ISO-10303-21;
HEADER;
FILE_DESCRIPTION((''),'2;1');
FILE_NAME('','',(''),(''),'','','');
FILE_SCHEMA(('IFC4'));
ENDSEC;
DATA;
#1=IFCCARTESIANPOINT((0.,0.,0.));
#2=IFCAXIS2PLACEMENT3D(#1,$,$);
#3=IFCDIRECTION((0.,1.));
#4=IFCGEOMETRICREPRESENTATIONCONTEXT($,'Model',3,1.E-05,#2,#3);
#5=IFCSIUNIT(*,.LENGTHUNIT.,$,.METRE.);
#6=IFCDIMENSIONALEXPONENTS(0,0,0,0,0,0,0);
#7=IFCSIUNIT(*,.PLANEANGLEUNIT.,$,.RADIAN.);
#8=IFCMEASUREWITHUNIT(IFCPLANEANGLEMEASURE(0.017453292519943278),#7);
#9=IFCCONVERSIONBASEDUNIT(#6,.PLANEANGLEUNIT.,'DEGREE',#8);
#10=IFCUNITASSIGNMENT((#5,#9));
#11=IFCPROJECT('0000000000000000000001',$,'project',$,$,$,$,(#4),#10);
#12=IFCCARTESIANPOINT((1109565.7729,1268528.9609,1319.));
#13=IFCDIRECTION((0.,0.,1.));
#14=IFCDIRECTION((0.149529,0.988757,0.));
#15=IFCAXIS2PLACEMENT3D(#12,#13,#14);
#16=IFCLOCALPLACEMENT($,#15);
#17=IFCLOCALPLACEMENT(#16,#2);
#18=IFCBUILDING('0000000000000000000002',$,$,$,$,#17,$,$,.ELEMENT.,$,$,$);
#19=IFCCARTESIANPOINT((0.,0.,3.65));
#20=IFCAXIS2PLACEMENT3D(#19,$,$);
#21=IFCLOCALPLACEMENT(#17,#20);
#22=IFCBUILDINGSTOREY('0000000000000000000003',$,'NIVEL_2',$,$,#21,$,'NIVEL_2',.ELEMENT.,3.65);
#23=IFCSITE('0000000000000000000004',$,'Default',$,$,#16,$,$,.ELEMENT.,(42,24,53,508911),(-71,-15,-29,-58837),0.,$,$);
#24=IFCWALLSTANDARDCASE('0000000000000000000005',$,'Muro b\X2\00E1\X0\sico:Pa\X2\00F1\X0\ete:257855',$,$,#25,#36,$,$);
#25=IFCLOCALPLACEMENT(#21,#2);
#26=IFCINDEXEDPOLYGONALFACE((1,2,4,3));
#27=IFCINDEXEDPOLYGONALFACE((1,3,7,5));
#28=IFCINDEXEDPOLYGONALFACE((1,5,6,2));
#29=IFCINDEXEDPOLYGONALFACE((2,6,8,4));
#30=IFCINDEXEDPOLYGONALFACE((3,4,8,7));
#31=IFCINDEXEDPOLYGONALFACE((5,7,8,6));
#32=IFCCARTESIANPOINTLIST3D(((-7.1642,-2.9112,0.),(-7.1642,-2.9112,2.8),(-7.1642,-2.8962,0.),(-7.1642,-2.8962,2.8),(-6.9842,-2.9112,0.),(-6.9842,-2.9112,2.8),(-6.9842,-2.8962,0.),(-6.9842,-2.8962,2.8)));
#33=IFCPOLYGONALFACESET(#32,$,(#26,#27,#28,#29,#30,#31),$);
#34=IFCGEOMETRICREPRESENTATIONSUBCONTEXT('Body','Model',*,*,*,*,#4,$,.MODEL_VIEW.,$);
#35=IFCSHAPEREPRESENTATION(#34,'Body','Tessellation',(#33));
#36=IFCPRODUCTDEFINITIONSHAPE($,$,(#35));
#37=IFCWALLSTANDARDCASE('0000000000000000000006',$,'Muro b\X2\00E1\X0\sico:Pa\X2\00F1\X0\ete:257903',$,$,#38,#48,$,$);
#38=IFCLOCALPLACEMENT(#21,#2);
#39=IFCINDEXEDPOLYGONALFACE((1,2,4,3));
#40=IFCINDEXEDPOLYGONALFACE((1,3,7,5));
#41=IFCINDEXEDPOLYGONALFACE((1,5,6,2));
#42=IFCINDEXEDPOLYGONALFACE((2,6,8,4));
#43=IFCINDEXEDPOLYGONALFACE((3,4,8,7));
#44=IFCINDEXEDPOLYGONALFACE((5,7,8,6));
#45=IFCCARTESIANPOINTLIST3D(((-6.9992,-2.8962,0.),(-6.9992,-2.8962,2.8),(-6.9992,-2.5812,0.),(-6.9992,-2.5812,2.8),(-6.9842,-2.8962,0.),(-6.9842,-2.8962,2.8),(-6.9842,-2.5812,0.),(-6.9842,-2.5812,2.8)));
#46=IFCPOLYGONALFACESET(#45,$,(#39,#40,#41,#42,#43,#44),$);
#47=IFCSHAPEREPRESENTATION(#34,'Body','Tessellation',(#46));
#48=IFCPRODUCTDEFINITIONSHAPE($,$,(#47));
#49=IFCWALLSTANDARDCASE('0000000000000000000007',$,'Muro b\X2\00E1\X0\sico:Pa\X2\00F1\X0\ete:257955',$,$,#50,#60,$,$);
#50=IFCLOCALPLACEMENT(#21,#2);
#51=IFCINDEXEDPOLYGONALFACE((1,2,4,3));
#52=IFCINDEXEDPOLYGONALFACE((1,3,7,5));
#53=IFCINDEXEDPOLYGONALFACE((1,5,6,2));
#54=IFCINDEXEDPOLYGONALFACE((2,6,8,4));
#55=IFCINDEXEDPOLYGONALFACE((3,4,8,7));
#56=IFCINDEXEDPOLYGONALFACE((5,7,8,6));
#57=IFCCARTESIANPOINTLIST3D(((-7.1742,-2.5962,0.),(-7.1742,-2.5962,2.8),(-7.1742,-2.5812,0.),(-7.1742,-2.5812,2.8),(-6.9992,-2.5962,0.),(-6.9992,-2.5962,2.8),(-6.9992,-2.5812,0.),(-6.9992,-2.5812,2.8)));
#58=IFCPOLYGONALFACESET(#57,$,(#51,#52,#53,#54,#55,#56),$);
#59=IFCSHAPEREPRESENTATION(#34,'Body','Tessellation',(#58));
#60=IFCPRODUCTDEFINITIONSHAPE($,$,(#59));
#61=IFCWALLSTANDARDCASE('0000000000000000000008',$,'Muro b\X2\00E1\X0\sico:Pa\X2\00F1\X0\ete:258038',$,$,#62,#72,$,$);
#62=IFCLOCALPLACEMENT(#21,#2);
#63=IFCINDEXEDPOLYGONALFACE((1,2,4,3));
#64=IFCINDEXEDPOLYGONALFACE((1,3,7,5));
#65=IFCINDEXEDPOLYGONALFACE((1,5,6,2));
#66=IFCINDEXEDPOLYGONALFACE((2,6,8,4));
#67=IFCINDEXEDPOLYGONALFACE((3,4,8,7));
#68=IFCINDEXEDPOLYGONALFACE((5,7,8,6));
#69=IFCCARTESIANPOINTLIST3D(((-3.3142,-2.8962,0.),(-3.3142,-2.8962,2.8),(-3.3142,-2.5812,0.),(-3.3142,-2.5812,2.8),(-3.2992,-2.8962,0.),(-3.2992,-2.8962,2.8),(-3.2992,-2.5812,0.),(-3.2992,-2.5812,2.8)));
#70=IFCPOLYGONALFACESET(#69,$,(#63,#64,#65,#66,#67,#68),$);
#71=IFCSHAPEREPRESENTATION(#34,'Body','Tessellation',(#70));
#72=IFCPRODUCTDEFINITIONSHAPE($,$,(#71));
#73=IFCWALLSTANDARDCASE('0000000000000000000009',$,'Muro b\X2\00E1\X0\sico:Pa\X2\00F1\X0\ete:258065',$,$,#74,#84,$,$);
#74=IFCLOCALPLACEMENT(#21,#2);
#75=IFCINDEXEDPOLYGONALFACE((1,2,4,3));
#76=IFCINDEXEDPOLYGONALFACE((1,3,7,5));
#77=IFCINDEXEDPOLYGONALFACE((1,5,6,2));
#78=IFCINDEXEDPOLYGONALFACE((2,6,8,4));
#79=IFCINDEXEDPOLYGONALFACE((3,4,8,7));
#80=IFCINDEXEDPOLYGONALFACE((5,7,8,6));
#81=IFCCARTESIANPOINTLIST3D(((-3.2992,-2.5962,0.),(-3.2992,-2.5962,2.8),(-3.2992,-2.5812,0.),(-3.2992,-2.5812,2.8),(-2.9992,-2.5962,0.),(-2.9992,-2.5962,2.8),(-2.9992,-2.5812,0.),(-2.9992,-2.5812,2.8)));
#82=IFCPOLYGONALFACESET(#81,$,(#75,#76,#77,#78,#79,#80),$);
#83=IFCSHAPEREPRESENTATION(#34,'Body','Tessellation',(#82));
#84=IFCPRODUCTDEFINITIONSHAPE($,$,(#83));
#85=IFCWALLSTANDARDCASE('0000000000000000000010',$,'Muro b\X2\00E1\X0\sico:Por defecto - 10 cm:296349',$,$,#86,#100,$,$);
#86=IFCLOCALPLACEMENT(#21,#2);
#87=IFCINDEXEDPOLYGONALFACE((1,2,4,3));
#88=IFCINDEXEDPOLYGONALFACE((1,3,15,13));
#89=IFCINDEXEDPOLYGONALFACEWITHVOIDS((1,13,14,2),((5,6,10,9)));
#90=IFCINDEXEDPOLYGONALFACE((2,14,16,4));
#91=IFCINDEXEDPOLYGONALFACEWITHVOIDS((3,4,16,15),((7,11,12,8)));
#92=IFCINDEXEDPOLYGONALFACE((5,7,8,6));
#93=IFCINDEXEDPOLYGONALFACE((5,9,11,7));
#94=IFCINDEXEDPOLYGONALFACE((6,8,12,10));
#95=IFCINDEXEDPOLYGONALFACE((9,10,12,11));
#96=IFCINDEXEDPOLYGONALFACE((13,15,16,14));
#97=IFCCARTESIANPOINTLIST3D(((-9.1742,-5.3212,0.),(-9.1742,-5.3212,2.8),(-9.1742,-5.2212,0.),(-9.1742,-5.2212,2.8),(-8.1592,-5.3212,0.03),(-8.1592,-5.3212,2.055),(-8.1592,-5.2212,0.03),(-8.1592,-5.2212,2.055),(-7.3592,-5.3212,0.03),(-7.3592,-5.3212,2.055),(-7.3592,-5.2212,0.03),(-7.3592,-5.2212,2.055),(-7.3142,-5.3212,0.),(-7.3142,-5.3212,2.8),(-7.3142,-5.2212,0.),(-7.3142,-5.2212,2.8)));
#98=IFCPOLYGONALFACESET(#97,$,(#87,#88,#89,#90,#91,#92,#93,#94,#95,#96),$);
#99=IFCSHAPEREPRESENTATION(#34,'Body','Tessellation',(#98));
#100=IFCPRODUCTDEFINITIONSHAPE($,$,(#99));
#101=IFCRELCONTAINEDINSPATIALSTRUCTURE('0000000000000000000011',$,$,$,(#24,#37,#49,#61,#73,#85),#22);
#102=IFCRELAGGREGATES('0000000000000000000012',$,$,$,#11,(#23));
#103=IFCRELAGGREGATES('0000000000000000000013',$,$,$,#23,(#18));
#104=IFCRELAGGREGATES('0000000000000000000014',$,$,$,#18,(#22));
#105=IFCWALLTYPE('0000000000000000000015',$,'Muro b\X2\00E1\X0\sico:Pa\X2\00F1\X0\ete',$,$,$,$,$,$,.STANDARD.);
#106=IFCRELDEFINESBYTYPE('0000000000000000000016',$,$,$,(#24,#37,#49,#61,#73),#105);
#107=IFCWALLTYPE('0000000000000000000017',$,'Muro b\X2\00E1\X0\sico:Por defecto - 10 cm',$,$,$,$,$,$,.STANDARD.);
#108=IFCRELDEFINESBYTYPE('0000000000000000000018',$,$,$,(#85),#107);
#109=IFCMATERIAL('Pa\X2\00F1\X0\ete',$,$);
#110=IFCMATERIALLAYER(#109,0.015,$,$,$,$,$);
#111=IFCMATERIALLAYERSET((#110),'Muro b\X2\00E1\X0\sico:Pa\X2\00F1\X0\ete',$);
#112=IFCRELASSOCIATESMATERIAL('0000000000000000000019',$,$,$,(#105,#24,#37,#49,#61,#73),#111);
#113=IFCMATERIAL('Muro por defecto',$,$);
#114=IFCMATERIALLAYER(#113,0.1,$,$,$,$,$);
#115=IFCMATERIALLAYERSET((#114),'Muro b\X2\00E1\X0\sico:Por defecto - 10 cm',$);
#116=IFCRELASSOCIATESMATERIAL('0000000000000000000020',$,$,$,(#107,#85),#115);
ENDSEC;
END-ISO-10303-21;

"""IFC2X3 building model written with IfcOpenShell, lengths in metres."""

from ifc_helpers import new_model, entity, si_unit, converted_unit, direction, frame, frame_2d, origin, place, context, subcontext, project, spatial, rectangle, extrude, material, layer, layer_set, layer_usage, type_object, element, save


model = new_model("IFC2X3")

# Units and contexts
model_context = context("Model", 3, precision=1e-05, world=origin(), true_north=direction((0.0, 1.0)))
body_context = subcontext(model_context, "Body", "Model", "MODEL_VIEW")
ifc_project = project(units=[si_unit("LENGTHUNIT", "METRE"), converted_unit("PLANEANGLEUNIT", "DEGREE", entity("IfcPlaneAngleMeasure", 0.017453292519943278), si_unit("PLANEANGLEUNIT", "RADIAN"), dimensions=[0, 0, 0, 0, 0, 0, 0])], contexts=[model_context])

# Site, building, storey
site_placement = place(None, frame((1109565.7729, 1268528.9609, 1319.0), z_axis=(0.0, 0.0, 1.0), x_axis=(0.149529, 0.988757, 0.0)))
site = spatial("IfcSite", under=ifc_project, at=site_placement, Name="Default", CompositionType="ELEMENT", RefLatitude=(42, 24, 53, 508911), RefLongitude=(-71, -15, -29, -58837), RefElevation=0.0)
building_placement = place(site_placement, origin())
building = spatial("IfcBuilding", under=site, at=building_placement, CompositionType="ELEMENT")
storey_placement = place(building_placement, frame((0.0, 0.0, 3.65)))
storey = spatial("IfcBuildingStorey", under=building, at=storey_placement, Name="NIVEL_2", LongName="NIVEL_2", CompositionType="ELEMENT", Elevation=3.65)

# Shared definitions
ifc_material_1 = material(Name="Pañete")

# Walls
ifc_layer_1 = layer(ifc_material_1, 0.015)
ifc_layer_set_1 = layer_set([ifc_layer_1], Name="Muro básico:Pañete")
wall_type_1 = type_object("IfcWallType", Name="Muro básico:Pañete", PredefinedType="STANDARD", material=ifc_layer_set_1)
ifc_layer_usage_1 = layer_usage(ifc_layer_set_1, "AXIS2", "POSITIVE", -0.0075)
wall_1_placement = place(storey_placement, frame((-7.1642, -2.9037, 0.0)))
element("IfcWallStandardCase", 1, at=wall_1_placement, inside=storey, type_object=wall_type_1, material=ifc_layer_usage_1, Name="Muro básico:Pañete:257855", context=body_context, shape_type="SweptSolid", body=[
    extrude(rectangle(XDim=0.18, YDim=0.015, at=frame_2d((0.09, 0.0), x_axis=(-1.0, 0.0))), origin(), (0.0, 0.0, 1.0), 2.8),
])
ifc_layer_usage_2 = layer_usage(ifc_layer_set_1, "AXIS2", "POSITIVE", -0.0075)
wall_2_placement = place(storey_placement, frame((-6.9917, -2.8962, 0.0), z_axis=(0.0, 0.0, 1.0), x_axis=(0.0, 1.0, 0.0)))
element("IfcWallStandardCase", 2, at=wall_2_placement, inside=storey, type_object=wall_type_1, material=ifc_layer_usage_2, Name="Muro básico:Pañete:257903", context=body_context, shape_type="SweptSolid", body=[
    extrude(rectangle(XDim=0.315, YDim=0.015, at=frame_2d((0.1575, 0.0), x_axis=(-1.0, 0.0))), origin(), (0.0, 0.0, 1.0), 2.8),
])
ifc_layer_usage_3 = layer_usage(ifc_layer_set_1, "AXIS2", "POSITIVE", -0.0075)
wall_3_placement = place(storey_placement, frame((-6.9992, -2.5887, 0.0), z_axis=(0.0, 0.0, 1.0), x_axis=(-1.0, 0.0, 0.0)))
element("IfcWallStandardCase", 3, at=wall_3_placement, inside=storey, type_object=wall_type_1, material=ifc_layer_usage_3, Name="Muro básico:Pañete:257955", context=body_context, shape_type="SweptSolid", body=[
    extrude(rectangle(XDim=0.175, YDim=0.015, at=frame_2d((0.0875, 0.0), x_axis=(-1.0, 0.0))), origin(), (0.0, 0.0, 1.0), 2.8),
])
ifc_layer_usage_4 = layer_usage(ifc_layer_set_1, "AXIS2", "NEGATIVE", 0.0075)
wall_4_placement = place(storey_placement, frame((-3.3067, -2.8962, 0.0), z_axis=(0.0, 0.0, 1.0), x_axis=(0.0, 1.0, 0.0)))
element("IfcWallStandardCase", 4, at=wall_4_placement, inside=storey, type_object=wall_type_1, material=ifc_layer_usage_4, Name="Muro básico:Pañete:258038", context=body_context, shape_type="SweptSolid", body=[
    extrude(rectangle(XDim=0.315, YDim=0.015, at=frame_2d((0.1575, 0.0), x_axis=(-1.0, 0.0))), origin(), (0.0, 0.0, 1.0), 2.8),
])
ifc_layer_usage_5 = layer_usage(ifc_layer_set_1, "AXIS2", "NEGATIVE", 0.0075)
wall_5_placement = place(storey_placement, frame((-3.2992, -2.5887, 0.0)))
element("IfcWallStandardCase", 5, at=wall_5_placement, inside=storey, type_object=wall_type_1, material=ifc_layer_usage_5, Name="Muro básico:Pañete:258065", context=body_context, shape_type="SweptSolid", body=[
    extrude(rectangle(XDim=0.3, YDim=0.015, at=frame_2d((0.15, 0.0), x_axis=(-1.0, 0.0))), origin(), (0.0, 0.0, 1.0), 2.8),
])

# Wall, opening
ifc_material_2 = material(Name="Muro por defecto")
ifc_layer_2 = layer(ifc_material_2, 0.1)
ifc_layer_set_2 = layer_set([ifc_layer_2], Name="Muro básico:Por defecto - 10 cm")
ifc_layer_usage_6 = layer_usage(ifc_layer_set_2, "AXIS2", "NEGATIVE", 0.05)
wall_type_2 = type_object("IfcWallType", Name="Muro básico:Por defecto - 10 cm", PredefinedType="STANDARD", material=ifc_layer_set_2)
wall_6_placement = place(storey_placement, frame((-9.1742, -5.2712, 0.0)))
wall_6 = element("IfcWallStandardCase", 6, at=wall_6_placement, inside=storey, type_object=wall_type_2, material=ifc_layer_usage_6, Name="Muro básico:Por defecto - 10 cm:296349", context=body_context, shape_type="SweptSolid", body=[
    extrude(rectangle(XDim=1.86, YDim=0.1, at=frame_2d((0.93, 0.0), x_axis=(-1.0, 0.0))), origin(), (0.0, 0.0, 1.0), 2.8),
])
opening_1_placement = place(wall_6_placement, frame((1.815, 0.05, 0.03)))
element("IfcOpeningElement", 7, at=opening_1_placement, cuts=wall_6, ObjectType="Opening", context=body_context, shape_type="SweptSolid", body=[
    extrude(rectangle(XDim=2.025, YDim=0.8, at=frame_2d((1.0125, 0.4), x_axis=(1.0, 0.0))), frame((0.0, 0.0, 0.0), z_axis=(0.0, -1.0, 0.0), x_axis=(0.0, 0.0, 1.0)), (0.0, 0.0, 1.0), 0.1),
])

save(model, "model.ifc")
